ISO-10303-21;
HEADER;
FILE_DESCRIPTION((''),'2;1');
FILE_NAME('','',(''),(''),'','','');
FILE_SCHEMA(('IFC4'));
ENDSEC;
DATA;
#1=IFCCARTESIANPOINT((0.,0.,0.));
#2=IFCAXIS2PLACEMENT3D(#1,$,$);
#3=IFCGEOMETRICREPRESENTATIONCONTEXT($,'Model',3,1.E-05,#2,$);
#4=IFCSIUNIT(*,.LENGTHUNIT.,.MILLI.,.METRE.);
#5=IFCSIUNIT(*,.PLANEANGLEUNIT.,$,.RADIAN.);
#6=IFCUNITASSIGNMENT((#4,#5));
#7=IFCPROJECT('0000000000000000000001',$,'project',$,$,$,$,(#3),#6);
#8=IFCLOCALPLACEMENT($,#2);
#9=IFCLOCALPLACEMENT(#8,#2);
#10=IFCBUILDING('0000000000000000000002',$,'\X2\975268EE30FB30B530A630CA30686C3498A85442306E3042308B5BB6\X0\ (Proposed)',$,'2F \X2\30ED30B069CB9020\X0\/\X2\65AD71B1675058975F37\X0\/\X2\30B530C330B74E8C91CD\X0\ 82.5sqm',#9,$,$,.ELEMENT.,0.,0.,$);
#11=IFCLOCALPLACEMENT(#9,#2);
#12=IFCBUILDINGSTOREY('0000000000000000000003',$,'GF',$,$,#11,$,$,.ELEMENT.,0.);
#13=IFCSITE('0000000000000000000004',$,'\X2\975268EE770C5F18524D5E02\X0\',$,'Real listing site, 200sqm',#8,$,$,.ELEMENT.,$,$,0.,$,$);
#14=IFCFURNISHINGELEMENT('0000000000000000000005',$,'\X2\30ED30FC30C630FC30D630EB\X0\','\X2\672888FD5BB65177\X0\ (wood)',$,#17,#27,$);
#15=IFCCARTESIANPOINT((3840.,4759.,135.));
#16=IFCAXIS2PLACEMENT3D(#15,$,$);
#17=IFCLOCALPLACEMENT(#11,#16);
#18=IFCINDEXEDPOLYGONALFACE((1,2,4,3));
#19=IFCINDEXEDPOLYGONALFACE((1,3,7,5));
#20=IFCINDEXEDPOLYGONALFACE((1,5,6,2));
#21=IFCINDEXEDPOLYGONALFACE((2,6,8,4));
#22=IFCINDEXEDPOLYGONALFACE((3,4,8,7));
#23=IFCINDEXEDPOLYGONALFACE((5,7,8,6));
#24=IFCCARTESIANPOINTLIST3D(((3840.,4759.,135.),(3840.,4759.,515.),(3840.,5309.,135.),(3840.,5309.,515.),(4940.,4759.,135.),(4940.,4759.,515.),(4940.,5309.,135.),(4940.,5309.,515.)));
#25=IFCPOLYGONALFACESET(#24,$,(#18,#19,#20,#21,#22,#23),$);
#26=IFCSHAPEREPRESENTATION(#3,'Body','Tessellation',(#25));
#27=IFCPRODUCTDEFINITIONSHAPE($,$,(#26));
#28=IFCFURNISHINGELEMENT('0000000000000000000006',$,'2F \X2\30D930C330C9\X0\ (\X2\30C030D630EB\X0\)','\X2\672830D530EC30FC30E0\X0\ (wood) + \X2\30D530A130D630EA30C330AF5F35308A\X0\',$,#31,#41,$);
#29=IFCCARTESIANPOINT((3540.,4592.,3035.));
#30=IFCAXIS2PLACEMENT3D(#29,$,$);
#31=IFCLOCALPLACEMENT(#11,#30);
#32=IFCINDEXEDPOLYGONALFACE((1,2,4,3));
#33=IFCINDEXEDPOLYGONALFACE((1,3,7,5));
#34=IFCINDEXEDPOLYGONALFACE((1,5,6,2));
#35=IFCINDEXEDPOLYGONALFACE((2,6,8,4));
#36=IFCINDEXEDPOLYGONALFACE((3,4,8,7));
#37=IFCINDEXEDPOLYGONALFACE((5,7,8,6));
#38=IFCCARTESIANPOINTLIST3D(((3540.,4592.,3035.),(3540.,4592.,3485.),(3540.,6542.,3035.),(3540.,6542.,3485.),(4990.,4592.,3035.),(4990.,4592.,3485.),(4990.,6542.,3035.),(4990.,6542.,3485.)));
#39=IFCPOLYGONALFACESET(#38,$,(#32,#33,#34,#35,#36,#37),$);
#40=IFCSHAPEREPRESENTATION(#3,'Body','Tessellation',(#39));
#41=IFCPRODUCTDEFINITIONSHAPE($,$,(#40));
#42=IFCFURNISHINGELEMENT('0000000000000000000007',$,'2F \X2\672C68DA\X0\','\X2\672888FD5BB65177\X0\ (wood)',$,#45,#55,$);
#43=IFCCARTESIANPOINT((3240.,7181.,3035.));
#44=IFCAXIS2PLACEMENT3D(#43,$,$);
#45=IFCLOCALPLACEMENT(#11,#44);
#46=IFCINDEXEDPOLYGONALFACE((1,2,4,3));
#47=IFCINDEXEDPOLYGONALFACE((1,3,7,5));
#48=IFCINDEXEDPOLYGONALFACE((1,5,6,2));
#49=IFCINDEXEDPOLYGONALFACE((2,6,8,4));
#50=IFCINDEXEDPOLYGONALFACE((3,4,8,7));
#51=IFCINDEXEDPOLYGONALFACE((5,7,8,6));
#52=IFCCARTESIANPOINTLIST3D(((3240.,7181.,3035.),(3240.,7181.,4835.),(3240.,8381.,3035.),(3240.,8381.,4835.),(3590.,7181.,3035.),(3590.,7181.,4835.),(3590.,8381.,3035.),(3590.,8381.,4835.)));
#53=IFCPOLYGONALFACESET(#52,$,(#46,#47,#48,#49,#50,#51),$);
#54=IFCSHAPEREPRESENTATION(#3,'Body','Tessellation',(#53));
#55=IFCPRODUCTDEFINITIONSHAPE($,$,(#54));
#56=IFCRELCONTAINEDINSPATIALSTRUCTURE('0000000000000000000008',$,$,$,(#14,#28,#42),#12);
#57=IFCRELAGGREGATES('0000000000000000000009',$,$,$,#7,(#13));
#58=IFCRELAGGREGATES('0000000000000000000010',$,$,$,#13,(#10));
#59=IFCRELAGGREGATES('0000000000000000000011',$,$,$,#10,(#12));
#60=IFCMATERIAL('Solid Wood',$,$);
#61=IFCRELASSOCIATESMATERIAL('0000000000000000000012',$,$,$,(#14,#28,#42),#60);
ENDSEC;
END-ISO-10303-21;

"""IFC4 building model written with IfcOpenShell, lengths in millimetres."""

from ifc_helpers import new_model, si_unit, frame, frame_2d, origin, place, context, project, spatial, rectangle, extrude, material, element, save


model = new_model("IFC4")

# Units and contexts
model_context = context("Model", 3, precision=1e-05, world=origin())
ifc_project = project(units=[si_unit("LENGTHUNIT", "METRE", prefix="MILLI"), si_unit("PLANEANGLEUNIT", "RADIAN")], contexts=[model_context])

# Site, building, storey
site_placement = place(None, origin())
site = spatial("IfcSite", under=ifc_project, at=site_placement, Name="青森県弘前市", ObjectType="Real listing site, 200sqm", CompositionType="ELEMENT", RefElevation=0.0)
building_placement = place(site_placement, origin())
building = spatial("IfcBuilding", under=site, at=building_placement, Name="青森・サウナと水風呂のある家 (Proposed)", ObjectType="2F ログ構造/断熱材増強/サッシ二重 82.5sqm", CompositionType="ELEMENT", ElevationOfRefHeight=0.0, ElevationOfTerrain=0.0)
storey_placement = place(building_placement, origin())
storey = spatial("IfcBuildingStorey", under=building, at=storey_placement, Name="GF", CompositionType="ELEMENT", Elevation=0.0)

# Shared definitions
ifc_material_1 = material(Name="Solid Wood")

# Furnishing elements
furnishing_1_placement = place(storey_placement, frame((3840.0, 4759.0, 135.0)))
element("IfcFurnishingElement", 1, at=furnishing_1_placement, inside=storey, material=ifc_material_1, Name="ローテーブル", Description="木製家具 (wood)", context=model_context, shape_type="SweptSolid", body=[
    extrude(rectangle(XDim=1100.0, YDim=550.0, at=frame_2d((550.0, 275.0))), frame((3840.0, 4759.0, 135.0)), (0.0, 0.0, 1.0), 380.0),
])
furnishing_2_placement = place(storey_placement, frame((3540.0, 4592.0, 3035.0)))
element("IfcFurnishingElement", 2, at=furnishing_2_placement, inside=storey, material=ifc_material_1, Name="2F ベッド (ダブル)", Description="木フレーム (wood) + ファブリック張り", context=model_context, shape_type="SweptSolid", body=[
    extrude(rectangle(XDim=1450.0, YDim=1950.0, at=frame_2d((725.0, 975.0))), frame((3540.0, 4592.0, 3035.0)), (0.0, 0.0, 1.0), 450.0),
])
furnishing_3_placement = place(storey_placement, frame((3240.0, 7181.0, 3035.0)))
element("IfcFurnishingElement", 3, at=furnishing_3_placement, inside=storey, material=ifc_material_1, Name="2F 本棚", Description="木製家具 (wood)", context=model_context, shape_type="SweptSolid", body=[
    extrude(rectangle(XDim=350.0, YDim=1200.0, at=frame_2d((175.0, 600.0))), frame((3240.0, 7181.0, 3035.0)), (0.0, 0.0, 1.0), 1800.0),
])

save(model, "model.ifc")
